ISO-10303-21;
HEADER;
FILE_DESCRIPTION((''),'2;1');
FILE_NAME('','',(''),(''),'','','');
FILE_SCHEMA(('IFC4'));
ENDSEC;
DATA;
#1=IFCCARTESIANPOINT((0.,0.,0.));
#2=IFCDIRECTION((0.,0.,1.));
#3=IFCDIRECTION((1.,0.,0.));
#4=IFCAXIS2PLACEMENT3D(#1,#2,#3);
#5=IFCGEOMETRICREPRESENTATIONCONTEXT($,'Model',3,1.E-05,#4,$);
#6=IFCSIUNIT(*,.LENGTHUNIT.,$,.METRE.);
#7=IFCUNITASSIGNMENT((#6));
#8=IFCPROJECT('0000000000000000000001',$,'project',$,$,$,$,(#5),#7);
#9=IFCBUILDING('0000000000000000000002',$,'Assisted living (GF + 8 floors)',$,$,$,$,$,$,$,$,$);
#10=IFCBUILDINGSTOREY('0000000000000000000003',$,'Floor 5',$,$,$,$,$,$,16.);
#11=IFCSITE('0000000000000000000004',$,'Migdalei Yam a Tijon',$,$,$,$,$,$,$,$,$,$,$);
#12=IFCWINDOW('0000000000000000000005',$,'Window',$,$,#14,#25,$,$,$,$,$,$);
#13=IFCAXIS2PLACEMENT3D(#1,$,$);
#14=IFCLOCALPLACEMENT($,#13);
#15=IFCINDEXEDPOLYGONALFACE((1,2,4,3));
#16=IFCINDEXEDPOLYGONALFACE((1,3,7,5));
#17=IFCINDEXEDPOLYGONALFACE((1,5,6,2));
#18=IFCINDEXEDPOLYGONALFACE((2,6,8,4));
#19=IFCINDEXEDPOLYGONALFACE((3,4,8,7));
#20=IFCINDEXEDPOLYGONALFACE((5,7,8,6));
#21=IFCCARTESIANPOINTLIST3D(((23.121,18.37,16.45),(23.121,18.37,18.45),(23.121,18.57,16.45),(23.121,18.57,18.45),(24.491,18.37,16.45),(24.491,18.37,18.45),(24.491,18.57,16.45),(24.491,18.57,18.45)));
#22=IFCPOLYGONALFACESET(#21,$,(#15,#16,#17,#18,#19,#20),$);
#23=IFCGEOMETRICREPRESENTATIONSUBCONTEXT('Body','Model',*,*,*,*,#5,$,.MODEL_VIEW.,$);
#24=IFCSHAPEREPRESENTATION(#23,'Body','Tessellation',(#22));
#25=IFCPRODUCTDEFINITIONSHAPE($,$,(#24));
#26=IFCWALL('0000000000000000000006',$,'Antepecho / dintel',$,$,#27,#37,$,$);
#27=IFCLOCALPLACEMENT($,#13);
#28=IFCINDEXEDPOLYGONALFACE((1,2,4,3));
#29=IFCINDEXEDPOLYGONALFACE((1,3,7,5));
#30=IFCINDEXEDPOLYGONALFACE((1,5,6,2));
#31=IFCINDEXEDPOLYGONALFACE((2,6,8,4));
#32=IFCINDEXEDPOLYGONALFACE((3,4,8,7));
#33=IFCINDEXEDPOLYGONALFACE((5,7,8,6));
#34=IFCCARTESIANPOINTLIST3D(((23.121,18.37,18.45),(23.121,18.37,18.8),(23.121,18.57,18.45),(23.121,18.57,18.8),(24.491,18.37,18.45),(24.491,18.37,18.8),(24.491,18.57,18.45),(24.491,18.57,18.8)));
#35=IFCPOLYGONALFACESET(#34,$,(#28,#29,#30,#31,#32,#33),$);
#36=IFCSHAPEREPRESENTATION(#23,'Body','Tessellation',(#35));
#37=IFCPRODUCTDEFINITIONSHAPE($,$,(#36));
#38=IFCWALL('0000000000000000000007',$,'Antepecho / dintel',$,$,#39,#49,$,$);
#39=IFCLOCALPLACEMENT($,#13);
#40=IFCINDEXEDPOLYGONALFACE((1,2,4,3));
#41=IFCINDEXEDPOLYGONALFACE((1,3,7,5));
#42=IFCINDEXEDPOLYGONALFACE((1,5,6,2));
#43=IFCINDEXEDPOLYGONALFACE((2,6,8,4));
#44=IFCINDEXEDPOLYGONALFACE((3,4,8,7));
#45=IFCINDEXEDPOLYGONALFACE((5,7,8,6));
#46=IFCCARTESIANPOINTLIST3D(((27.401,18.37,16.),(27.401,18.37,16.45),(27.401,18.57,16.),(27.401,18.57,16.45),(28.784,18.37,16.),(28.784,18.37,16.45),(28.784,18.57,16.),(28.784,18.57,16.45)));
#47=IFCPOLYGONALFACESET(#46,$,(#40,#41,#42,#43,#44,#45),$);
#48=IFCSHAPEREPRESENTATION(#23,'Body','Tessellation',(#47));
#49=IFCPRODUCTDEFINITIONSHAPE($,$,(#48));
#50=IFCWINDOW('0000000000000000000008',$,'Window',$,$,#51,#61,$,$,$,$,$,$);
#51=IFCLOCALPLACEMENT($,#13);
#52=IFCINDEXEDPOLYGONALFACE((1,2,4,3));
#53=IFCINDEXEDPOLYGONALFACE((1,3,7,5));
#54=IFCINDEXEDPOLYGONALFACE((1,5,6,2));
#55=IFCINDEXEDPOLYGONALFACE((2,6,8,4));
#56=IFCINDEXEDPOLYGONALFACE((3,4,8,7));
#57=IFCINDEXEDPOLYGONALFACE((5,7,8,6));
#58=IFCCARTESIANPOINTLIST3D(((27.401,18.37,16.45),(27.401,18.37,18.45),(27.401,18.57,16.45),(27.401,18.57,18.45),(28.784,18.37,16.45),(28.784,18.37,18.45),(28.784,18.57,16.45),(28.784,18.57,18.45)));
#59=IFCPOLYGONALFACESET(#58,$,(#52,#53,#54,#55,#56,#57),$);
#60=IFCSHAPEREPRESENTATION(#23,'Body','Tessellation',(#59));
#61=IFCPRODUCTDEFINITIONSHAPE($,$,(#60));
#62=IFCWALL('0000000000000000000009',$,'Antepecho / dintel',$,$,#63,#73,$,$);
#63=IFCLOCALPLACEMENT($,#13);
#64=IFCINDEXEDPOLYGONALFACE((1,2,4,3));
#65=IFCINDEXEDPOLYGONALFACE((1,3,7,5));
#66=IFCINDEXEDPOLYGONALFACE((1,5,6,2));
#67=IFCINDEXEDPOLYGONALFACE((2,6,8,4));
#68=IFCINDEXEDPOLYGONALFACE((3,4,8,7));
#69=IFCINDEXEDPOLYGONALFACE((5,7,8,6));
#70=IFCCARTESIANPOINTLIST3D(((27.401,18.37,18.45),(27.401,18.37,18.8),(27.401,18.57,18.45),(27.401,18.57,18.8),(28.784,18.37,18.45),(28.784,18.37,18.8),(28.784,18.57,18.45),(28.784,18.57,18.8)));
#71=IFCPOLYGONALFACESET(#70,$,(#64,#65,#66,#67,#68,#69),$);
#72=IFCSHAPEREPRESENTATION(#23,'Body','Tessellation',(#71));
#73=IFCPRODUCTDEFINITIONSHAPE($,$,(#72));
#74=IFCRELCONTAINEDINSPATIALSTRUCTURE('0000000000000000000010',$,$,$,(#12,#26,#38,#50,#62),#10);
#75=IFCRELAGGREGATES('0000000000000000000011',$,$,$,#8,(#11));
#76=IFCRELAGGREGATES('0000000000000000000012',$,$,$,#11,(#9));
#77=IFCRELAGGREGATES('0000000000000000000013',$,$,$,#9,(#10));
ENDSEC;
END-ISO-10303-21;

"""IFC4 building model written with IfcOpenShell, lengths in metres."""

from ifc_helpers import new_model, si_unit, frame, origin_with_axes, context, subcontext, project, spatial, line, indexed_curve, outline, extrude, element, save


model = new_model("IFC4")

# Units and contexts
model_context = context("Model", 3, precision=1e-05, world=origin_with_axes())
body_context = subcontext(model_context, "Body", "Model", "MODEL_VIEW")
ifc_project = project(units=[si_unit("LENGTHUNIT", "METRE")], contexts=[model_context])

# Site, building, storey
site = spatial("IfcSite", under=ifc_project, Name="Migdalei Yam a Tijon")
building = spatial("IfcBuilding", under=site, Name="Assisted living (GF + 8 floors)")
storey = spatial("IfcBuildingStorey", under=building, Name="Floor 5", Elevation=16.0)

# Window
element("IfcWindow", 1, inside=storey, Name="Window", context=body_context, shape_type="SweptSolid", body=[
    extrude(outline(indexed_curve([(0.0, 0.0), (1.37, 0.0), (1.37, 0.2), (0.0, 0.2)], segments=[line(1, 2, 3, 4, 1)])), frame((23.121, 18.37, 16.45), z_axis=(0.0, 0.0, 1.0), x_axis=(1.0, 0.0, 0.0)), (0.0, 0.0, 1.0), 2.0),
])

# Walls
element("IfcWall", 2, inside=storey, Name="Antepecho / dintel", context=body_context, shape_type="SweptSolid", body=[
    extrude(outline(indexed_curve([(0.0, 0.0), (1.37, 0.0), (1.37, 0.2), (0.0, 0.2)], segments=[line(1, 2, 3, 4, 1)])), frame((23.121, 18.37, 18.45), z_axis=(0.0, 0.0, 1.0), x_axis=(1.0, 0.0, 0.0)), (0.0, 0.0, 1.0), 0.35),
])
element("IfcWall", 3, inside=storey, Name="Antepecho / dintel", context=body_context, shape_type="SweptSolid", body=[
    extrude(outline(indexed_curve([(0.0, 0.0), (1.383, 0.0), (1.383, 0.2), (0.0, 0.2)], segments=[line(1, 2, 3, 4, 1)])), frame((27.401, 18.37, 16.0), z_axis=(0.0, 0.0, 1.0), x_axis=(1.0, 0.0, 0.0)), (0.0, 0.0, 1.0), 0.45),
])

# Window
element("IfcWindow", 4, inside=storey, Name="Window", context=body_context, shape_type="SweptSolid", body=[
    extrude(outline(indexed_curve([(0.0, 0.0), (1.383, 0.0), (1.383, 0.2), (0.0, 0.2)], segments=[line(1, 2, 3, 4, 1)])), frame((27.401, 18.37, 16.45), z_axis=(0.0, 0.0, 1.0), x_axis=(1.0, 0.0, 0.0)), (0.0, 0.0, 1.0), 2.0),
])

# Wall
element("IfcWall", 5, inside=storey, Name="Antepecho / dintel", context=body_context, shape_type="SweptSolid", body=[
    extrude(outline(indexed_curve([(0.0, 0.0), (1.383, 0.0), (1.383, 0.2), (0.0, 0.2)], segments=[line(1, 2, 3, 4, 1)])), frame((27.401, 18.37, 18.45), z_axis=(0.0, 0.0, 1.0), x_axis=(1.0, 0.0, 0.0)), (0.0, 0.0, 1.0), 0.35),
])

save(model, "model.ifc")
